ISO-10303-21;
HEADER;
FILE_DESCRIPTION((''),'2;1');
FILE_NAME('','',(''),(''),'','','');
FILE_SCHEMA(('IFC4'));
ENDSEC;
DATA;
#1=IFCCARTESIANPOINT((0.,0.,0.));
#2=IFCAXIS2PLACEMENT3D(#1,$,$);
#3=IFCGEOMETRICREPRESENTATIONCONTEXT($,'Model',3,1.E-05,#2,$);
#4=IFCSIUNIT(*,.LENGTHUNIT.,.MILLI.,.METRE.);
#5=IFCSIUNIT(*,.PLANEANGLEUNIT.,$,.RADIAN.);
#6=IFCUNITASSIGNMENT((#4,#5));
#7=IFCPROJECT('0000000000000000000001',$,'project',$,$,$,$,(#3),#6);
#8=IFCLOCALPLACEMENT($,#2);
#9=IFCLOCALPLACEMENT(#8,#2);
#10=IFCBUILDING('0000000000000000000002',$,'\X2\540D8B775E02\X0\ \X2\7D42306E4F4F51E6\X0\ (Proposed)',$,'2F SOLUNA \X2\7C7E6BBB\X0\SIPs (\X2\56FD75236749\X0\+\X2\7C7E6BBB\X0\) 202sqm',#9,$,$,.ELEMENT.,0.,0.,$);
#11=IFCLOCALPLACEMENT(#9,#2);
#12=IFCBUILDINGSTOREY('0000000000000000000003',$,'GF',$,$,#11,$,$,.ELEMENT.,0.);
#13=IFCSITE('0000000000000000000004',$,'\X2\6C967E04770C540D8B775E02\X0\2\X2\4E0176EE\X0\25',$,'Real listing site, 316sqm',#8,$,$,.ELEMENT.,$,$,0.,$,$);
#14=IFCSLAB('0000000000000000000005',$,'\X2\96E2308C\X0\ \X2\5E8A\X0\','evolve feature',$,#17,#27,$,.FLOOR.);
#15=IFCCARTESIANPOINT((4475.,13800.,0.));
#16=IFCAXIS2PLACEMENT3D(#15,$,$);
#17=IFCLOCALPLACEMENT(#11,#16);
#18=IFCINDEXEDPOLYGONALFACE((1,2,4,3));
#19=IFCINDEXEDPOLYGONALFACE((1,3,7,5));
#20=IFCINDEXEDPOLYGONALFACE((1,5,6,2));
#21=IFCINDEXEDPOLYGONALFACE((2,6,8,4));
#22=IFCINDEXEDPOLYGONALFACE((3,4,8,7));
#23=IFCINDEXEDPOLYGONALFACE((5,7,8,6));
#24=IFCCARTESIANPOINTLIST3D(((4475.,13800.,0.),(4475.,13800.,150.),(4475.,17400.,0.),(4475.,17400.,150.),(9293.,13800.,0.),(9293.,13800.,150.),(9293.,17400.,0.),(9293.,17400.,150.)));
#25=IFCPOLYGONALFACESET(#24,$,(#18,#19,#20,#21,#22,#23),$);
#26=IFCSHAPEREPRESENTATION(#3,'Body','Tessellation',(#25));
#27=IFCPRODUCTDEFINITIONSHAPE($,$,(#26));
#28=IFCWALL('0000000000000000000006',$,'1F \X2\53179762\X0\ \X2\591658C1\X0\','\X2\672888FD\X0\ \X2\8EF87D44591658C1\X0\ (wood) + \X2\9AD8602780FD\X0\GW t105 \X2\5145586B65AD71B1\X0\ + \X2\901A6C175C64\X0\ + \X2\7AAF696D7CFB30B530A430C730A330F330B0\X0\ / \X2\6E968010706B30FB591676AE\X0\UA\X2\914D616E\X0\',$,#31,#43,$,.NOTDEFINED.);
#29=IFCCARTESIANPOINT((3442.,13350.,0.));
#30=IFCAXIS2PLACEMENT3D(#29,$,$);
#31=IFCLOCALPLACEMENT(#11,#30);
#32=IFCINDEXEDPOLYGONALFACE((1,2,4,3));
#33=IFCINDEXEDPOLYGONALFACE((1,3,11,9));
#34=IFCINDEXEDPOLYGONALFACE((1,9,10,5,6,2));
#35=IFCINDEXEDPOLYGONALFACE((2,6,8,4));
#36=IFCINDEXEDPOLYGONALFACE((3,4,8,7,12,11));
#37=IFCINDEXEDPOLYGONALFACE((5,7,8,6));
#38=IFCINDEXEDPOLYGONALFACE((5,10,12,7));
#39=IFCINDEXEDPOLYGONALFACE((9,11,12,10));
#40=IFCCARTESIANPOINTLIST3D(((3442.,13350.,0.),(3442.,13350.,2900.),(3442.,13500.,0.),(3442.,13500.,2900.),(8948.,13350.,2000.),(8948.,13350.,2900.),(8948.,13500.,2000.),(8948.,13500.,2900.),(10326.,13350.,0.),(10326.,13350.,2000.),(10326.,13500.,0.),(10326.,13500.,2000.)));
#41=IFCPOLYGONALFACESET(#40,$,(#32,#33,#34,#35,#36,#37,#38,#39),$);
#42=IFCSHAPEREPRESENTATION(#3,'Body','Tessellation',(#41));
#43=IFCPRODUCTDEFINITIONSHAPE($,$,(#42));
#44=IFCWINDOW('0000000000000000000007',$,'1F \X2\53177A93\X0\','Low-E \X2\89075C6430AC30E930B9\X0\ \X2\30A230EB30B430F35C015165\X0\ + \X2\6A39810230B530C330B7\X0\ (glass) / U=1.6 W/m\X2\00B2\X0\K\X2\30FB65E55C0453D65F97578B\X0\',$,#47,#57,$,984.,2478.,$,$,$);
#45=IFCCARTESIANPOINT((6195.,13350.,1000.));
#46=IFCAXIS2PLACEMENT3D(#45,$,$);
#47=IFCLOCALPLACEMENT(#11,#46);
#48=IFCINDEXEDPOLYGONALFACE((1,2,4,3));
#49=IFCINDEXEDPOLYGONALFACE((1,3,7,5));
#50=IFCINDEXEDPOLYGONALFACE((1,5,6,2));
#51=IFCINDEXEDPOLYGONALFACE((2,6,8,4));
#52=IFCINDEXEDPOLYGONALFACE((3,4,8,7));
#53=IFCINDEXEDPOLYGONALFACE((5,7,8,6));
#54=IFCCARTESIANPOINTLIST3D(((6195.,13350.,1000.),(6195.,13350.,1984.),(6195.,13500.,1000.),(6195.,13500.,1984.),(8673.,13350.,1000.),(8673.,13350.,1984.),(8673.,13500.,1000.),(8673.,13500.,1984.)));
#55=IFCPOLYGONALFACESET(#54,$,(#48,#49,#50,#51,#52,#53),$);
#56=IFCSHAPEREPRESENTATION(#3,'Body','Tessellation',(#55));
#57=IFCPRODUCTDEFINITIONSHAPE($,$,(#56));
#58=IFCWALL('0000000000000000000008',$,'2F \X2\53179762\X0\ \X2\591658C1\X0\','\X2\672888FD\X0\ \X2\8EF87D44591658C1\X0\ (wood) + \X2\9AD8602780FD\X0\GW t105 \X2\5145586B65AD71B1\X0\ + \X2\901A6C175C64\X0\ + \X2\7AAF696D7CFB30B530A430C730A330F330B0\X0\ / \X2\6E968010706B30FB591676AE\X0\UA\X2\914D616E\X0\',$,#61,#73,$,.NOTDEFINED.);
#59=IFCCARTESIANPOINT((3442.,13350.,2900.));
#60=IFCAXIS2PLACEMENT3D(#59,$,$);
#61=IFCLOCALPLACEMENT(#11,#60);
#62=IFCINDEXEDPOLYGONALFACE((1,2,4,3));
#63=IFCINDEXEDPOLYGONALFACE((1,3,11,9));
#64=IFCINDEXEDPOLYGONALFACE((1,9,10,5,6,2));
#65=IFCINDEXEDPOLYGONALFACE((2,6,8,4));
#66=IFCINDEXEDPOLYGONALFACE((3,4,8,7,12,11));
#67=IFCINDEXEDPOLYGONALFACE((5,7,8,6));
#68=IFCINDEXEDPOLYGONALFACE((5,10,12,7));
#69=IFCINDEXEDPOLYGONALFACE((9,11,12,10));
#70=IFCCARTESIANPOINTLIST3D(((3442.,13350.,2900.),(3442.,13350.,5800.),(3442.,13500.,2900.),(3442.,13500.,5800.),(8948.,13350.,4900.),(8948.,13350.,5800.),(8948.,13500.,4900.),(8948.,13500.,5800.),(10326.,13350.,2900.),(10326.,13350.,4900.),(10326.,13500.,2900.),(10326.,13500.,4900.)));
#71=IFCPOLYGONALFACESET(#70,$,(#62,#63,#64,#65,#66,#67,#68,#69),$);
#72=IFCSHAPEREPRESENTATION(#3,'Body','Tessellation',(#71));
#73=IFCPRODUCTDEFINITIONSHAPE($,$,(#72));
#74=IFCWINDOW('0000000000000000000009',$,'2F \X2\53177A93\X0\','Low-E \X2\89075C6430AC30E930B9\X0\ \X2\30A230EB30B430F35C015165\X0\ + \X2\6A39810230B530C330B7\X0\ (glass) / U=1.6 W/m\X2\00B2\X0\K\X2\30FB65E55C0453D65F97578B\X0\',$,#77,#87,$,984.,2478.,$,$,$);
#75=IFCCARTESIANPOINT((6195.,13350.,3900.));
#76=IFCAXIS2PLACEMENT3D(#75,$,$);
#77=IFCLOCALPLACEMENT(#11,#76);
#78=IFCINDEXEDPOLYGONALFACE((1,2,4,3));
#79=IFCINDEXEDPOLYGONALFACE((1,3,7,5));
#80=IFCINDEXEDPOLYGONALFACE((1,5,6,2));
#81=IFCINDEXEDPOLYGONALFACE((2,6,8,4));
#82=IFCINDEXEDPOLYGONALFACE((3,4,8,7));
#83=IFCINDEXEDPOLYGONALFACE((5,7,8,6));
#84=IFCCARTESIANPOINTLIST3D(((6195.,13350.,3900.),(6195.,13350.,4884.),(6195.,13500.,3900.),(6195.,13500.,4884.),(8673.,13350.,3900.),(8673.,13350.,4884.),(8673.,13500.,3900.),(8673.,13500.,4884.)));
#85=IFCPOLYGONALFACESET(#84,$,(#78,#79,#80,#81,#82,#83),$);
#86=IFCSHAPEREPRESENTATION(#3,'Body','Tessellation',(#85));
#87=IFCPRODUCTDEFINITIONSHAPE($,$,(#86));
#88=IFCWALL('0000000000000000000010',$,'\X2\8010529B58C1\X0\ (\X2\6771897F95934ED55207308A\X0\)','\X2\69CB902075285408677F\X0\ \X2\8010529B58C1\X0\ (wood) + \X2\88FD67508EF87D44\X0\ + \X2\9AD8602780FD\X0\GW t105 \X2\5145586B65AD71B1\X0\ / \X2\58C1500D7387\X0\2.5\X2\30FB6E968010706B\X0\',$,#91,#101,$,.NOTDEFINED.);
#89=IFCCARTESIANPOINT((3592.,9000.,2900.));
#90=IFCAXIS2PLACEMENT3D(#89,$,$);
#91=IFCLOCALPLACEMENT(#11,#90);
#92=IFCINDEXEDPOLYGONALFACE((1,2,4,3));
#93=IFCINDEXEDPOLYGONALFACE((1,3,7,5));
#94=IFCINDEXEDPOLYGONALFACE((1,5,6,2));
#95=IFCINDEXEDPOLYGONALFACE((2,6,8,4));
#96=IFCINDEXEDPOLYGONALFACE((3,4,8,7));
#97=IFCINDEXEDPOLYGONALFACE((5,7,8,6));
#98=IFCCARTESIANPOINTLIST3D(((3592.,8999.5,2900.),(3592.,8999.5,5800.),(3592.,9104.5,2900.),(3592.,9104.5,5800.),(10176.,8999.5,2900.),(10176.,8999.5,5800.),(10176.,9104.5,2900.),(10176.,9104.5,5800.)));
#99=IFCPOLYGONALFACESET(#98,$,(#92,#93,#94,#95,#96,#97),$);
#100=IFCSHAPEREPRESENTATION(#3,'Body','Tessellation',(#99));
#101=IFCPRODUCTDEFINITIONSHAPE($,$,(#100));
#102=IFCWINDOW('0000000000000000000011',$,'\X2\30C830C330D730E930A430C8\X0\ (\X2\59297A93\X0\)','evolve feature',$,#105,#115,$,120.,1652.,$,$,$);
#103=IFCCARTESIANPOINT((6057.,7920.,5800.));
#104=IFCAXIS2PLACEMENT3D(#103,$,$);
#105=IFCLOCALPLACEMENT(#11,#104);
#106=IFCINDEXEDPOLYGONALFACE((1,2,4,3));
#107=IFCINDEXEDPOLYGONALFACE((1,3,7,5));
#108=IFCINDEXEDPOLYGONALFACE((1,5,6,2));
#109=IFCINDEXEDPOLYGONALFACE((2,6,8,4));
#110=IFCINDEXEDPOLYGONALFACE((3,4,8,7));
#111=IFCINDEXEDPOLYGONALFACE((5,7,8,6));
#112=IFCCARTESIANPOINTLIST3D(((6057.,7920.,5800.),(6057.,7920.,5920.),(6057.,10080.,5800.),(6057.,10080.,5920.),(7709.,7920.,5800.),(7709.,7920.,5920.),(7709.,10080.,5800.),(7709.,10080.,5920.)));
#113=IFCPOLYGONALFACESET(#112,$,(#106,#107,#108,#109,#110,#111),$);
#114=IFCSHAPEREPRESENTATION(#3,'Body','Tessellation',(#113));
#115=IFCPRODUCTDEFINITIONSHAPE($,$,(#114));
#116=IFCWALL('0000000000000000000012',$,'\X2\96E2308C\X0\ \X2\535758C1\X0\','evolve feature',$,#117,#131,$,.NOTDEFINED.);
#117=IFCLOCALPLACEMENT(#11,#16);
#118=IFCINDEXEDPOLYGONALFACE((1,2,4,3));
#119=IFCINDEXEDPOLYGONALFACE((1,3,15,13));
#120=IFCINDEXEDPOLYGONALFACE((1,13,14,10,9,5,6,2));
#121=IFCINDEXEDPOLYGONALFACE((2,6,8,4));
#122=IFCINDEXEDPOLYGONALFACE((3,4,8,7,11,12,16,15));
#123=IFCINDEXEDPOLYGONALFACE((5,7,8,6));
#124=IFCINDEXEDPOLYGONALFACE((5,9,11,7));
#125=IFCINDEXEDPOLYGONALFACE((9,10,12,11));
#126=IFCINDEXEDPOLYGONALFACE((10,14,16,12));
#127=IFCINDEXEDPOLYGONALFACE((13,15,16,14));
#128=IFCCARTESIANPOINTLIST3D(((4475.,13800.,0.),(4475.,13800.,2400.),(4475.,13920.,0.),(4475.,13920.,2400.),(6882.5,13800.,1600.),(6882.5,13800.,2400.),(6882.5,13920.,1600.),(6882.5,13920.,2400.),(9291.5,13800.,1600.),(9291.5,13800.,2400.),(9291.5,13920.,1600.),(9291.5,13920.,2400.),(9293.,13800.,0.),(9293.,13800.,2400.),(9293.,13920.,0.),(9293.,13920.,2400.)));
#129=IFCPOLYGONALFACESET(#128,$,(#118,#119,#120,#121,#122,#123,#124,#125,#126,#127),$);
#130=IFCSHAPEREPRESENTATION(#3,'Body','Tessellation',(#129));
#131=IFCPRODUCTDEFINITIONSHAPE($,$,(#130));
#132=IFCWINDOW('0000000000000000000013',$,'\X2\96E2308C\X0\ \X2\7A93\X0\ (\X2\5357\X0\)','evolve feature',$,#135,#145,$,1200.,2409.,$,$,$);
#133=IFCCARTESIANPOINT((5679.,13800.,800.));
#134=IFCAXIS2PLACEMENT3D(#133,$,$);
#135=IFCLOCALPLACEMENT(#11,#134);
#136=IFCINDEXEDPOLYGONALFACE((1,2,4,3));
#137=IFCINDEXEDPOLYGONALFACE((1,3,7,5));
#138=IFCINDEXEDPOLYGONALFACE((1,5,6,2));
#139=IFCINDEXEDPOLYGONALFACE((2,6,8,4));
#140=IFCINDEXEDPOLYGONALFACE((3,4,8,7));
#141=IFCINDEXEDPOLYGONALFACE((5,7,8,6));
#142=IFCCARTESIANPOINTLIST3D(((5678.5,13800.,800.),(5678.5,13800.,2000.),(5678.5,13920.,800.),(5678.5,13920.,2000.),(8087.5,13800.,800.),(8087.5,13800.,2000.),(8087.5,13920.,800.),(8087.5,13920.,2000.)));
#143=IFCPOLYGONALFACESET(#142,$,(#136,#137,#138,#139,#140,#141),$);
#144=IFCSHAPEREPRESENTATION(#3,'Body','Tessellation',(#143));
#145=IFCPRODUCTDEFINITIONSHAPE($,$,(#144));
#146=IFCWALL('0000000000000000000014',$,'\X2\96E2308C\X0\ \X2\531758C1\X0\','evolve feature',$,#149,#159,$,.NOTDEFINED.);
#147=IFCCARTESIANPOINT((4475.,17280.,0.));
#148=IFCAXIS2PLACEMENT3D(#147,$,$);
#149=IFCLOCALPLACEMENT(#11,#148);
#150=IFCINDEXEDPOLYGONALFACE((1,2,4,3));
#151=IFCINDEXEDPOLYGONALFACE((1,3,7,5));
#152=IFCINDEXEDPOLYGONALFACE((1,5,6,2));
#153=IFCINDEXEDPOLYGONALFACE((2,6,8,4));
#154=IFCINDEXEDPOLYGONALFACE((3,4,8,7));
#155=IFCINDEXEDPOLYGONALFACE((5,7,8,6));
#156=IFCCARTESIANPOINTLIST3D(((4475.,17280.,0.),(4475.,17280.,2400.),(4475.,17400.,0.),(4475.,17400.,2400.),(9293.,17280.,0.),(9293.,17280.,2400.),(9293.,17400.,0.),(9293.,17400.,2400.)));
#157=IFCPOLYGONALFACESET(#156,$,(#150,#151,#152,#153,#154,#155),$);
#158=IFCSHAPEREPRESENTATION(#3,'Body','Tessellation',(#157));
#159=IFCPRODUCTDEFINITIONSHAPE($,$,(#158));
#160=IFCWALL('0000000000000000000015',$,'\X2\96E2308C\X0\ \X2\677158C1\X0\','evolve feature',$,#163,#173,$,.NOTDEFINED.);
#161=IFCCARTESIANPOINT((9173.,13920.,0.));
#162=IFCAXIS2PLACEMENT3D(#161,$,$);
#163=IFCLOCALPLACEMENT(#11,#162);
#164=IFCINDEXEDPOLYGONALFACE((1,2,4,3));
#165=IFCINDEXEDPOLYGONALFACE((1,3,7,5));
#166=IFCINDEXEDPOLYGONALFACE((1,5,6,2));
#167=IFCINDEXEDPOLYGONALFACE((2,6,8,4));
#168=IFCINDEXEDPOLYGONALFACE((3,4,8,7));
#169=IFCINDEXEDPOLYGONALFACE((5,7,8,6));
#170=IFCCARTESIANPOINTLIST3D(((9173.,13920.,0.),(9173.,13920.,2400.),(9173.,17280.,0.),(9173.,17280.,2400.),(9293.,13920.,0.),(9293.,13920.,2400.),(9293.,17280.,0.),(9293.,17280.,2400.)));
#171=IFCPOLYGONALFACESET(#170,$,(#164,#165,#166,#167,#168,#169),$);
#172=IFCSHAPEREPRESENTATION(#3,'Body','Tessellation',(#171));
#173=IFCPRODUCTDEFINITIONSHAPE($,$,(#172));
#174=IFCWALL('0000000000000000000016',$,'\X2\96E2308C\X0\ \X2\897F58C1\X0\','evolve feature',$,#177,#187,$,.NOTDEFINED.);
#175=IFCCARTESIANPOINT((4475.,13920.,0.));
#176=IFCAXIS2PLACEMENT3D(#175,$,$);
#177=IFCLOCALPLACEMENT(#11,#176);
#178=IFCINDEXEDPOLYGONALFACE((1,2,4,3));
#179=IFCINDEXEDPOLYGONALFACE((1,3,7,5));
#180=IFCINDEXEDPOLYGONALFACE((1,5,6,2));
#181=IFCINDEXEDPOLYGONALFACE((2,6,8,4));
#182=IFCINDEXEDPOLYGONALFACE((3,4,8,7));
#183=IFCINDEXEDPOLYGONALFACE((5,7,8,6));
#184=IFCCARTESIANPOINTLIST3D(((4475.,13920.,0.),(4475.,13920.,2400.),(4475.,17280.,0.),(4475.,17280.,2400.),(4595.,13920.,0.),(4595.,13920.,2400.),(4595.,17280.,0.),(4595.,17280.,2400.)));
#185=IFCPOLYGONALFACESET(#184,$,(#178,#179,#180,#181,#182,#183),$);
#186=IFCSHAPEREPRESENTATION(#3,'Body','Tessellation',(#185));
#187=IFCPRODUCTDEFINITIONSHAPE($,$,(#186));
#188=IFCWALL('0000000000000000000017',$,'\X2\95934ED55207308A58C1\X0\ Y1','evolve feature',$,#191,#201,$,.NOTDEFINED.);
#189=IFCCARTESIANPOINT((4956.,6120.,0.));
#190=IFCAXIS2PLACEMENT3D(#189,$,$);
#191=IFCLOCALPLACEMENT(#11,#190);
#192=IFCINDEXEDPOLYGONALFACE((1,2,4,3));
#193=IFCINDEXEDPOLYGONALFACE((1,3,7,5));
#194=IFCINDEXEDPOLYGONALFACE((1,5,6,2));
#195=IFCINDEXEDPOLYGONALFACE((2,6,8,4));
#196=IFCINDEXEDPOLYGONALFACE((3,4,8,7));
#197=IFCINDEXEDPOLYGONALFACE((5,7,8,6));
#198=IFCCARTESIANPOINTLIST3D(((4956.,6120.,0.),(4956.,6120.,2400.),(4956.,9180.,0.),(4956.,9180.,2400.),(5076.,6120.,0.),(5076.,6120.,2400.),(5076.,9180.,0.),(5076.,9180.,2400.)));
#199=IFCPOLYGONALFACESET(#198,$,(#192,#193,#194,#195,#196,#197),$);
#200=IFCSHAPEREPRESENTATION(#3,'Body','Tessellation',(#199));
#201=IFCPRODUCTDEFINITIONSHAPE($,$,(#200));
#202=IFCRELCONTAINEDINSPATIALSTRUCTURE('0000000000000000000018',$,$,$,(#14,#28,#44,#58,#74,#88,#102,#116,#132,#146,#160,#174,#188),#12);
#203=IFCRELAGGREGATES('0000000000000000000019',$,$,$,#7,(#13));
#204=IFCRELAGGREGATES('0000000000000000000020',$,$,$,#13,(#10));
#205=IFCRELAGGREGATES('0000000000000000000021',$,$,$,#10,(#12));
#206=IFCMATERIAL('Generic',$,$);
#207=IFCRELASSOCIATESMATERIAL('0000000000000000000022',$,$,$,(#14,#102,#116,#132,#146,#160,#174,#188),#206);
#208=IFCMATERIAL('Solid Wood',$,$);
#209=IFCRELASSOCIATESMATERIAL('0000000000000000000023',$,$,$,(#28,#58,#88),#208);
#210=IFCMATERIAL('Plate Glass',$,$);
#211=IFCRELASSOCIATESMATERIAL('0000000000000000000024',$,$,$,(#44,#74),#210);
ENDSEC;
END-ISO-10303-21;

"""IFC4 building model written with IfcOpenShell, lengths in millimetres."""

from ifc_helpers import new_model, si_unit, frame, frame_2d, origin, place, context, project, spatial, rectangle, extrude, material, element, fill, save


model = new_model("IFC4")

# Units and contexts
model_context = context("Model", 3, precision=1e-05, world=origin())
ifc_project = project(units=[si_unit("LENGTHUNIT", "METRE", prefix="MILLI"), si_unit("PLANEANGLEUNIT", "RADIAN")], contexts=[model_context])

# Site, building, storey
site_placement = place(None, origin())
site = spatial("IfcSite", under=ifc_project, at=site_placement, Name="沖縄県名護市2丁目25", ObjectType="Real listing site, 316sqm", CompositionType="ELEMENT", RefElevation=0.0)
building_placement = place(site_placement, origin())
building = spatial("IfcBuilding", under=site, at=building_placement, Name="名護市 終の住処 (Proposed)", ObjectType="2F SOLUNA 籾殻SIPs (国産杉+籾殻) 202sqm", CompositionType="ELEMENT", ElevationOfRefHeight=0.0, ElevationOfTerrain=0.0)
storey_placement = place(building_placement, origin())
storey = spatial("IfcBuildingStorey", under=building, at=storey_placement, Name="GF", CompositionType="ELEMENT", Elevation=0.0)

# Slab
ifc_material_1 = material(Name="Generic")
slab_placement = place(storey_placement, frame((4475.0, 13800.0, 0.0)))
element("IfcSlab", 1, at=slab_placement, inside=storey, material=ifc_material_1, Name="離れ 床", Description="evolve feature", PredefinedType="FLOOR", context=model_context, shape_type="SweptSolid", body=[
    extrude(rectangle(XDim=4818.0, YDim=3600.0, at=frame_2d((2409.0, 1800.0))), frame((4475.0, 13800.0, 0.0)), (0.0, 0.0, 1.0), 150.0),
])

# Wall, opening, window
ifc_material_2 = material(Name="Solid Wood")
wall_1_placement = place(storey_placement, frame((3442.0, 13350.0, 0.0)))
wall_1 = element("IfcWall", 2, at=wall_1_placement, inside=storey, material=ifc_material_2, Name="1F 北面 外壁", Description="木製 軸組外壁 (wood) + 高性能GW t105 充填断熱 + 通気層 + 窯業系サイディング / 準耐火・外皮UA配慮", PredefinedType="NOTDEFINED", context=model_context, shape_type="SweptSolid", body=[
    extrude(rectangle(XDim=6884.0, YDim=150.0, at=frame_2d((3442.0, 75.0))), frame((3442.0, 13350.0, 0.0)), (0.0, 0.0, 1.0), 2900.0),
])
opening_1_placement = place(storey_placement, frame((6195.0, 13350.0, 1000.0)))
opening_1 = element("IfcOpeningElement", 3, at=opening_1_placement, cuts=wall_1, PredefinedType="NOTDEFINED", context=model_context, shape_type="SweptSolid", body=[
    extrude(rectangle(XDim=2478.0, YDim=150.0, at=frame_2d((1239.0, 75.0))), frame((6195.0, 13350.0, 1000.0)), (0.0, 0.0, 1.0), 984.0),
])
ifc_material_3 = material(Name="Plate Glass")
window_1_placement = place(storey_placement, frame((6195.0, 13350.0, 1000.0)))
window_1 = element("IfcWindow", 4, at=window_1_placement, inside=storey, material=ifc_material_3, Name="1F 北窓", Description="Low-E 複層ガラス アルゴン封入 + 樹脂サッシ (glass) / U=1.6 W/m²K・日射取得型", OverallHeight=984.0, OverallWidth=2478.0, context=model_context, shape_type="SweptSolid", body=[
    extrude(rectangle(XDim=2478.0, YDim=150.0, at=frame_2d((1239.0, 75.0))), frame((6195.0, 13350.0, 1000.0)), (0.0, 0.0, 1.0), 984.0),
])
fill(opening_1, window_1)

# Wall, opening, window
wall_2_placement = place(storey_placement, frame((3442.0, 13350.0, 2900.0)))
wall_2 = element("IfcWall", 5, at=wall_2_placement, inside=storey, material=ifc_material_2, Name="2F 北面 外壁", Description="木製 軸組外壁 (wood) + 高性能GW t105 充填断熱 + 通気層 + 窯業系サイディング / 準耐火・外皮UA配慮", PredefinedType="NOTDEFINED", context=model_context, shape_type="SweptSolid", body=[
    extrude(rectangle(XDim=6884.0, YDim=150.0, at=frame_2d((3442.0, 75.0))), frame((3442.0, 13350.0, 2900.0)), (0.0, 0.0, 1.0), 2900.0),
])
opening_2_placement = place(storey_placement, frame((6195.0, 13350.0, 3900.0)))
opening_2 = element("IfcOpeningElement", 6, at=opening_2_placement, cuts=wall_2, PredefinedType="NOTDEFINED", context=model_context, shape_type="SweptSolid", body=[
    extrude(rectangle(XDim=2478.0, YDim=150.0, at=frame_2d((1239.0, 75.0))), frame((6195.0, 13350.0, 3900.0)), (0.0, 0.0, 1.0), 984.0),
])
window_2_placement = place(storey_placement, frame((6195.0, 13350.0, 3900.0)))
window_2 = element("IfcWindow", 7, at=window_2_placement, inside=storey, material=ifc_material_3, Name="2F 北窓", Description="Low-E 複層ガラス アルゴン封入 + 樹脂サッシ (glass) / U=1.6 W/m²K・日射取得型", OverallHeight=984.0, OverallWidth=2478.0, context=model_context, shape_type="SweptSolid", body=[
    extrude(rectangle(XDim=2478.0, YDim=150.0, at=frame_2d((1239.0, 75.0))), frame((6195.0, 13350.0, 3900.0)), (0.0, 0.0, 1.0), 984.0),
])
fill(opening_2, window_2)

# Wall
wall_3_placement = place(storey_placement, frame((3592.0, 9000.0, 2900.0)))
element("IfcWall", 8, at=wall_3_placement, inside=storey, material=ifc_material_2, Name="耐力壁 (東西間仕切り)", Description="構造用合板 耐力壁 (wood) + 製材軸組 + 高性能GW t105 充填断熱 / 壁倍率2.5・準耐火", PredefinedType="NOTDEFINED", context=model_context, shape_type="SweptSolid", body=[
    extrude(rectangle(XDim=6584.0, YDim=105.0, at=frame_2d((3292.0, 52.0))), frame((3592.0, 9000.0, 2900.0)), (0.0, 0.0, 1.0), 2900.0),
])

# Window
window_3_placement = place(storey_placement, frame((6057.0, 7920.0, 5800.0)))
element("IfcWindow", 9, at=window_3_placement, inside=storey, material=ifc_material_1, Name="トップライト (天窓)", Description="evolve feature", OverallHeight=120.0, OverallWidth=1652.0, context=model_context, shape_type="SweptSolid", body=[
    extrude(rectangle(XDim=1652.0, YDim=2160.0, at=frame_2d((826.0, 1080.0))), frame((6057.0, 7920.0, 5800.0)), (0.0, 0.0, 1.0), 120.0),
])

# Wall, opening, window
wall_4_placement = place(storey_placement, frame((4475.0, 13800.0, 0.0)))
wall_4 = element("IfcWall", 10, at=wall_4_placement, inside=storey, material=ifc_material_1, Name="離れ 南壁", Description="evolve feature", PredefinedType="NOTDEFINED", context=model_context, shape_type="SweptSolid", body=[
    extrude(rectangle(XDim=4818.0, YDim=120.0, at=frame_2d((2409.0, 60.0))), frame((4475.0, 13800.0, 0.0)), (0.0, 0.0, 1.0), 2400.0),
])
opening_3_placement = place(storey_placement, frame((5679.0, 13800.0, 800.0)))
opening_3 = element("IfcOpeningElement", 11, at=opening_3_placement, cuts=wall_4, PredefinedType="NOTDEFINED", context=model_context, shape_type="SweptSolid", body=[
    extrude(rectangle(XDim=2409.0, YDim=120.0, at=frame_2d((1204.0, 60.0))), frame((5679.0, 13800.0, 800.0)), (0.0, 0.0, 1.0), 1200.0),
])
window_4_placement = place(storey_placement, frame((5679.0, 13800.0, 800.0)))
window_4 = element("IfcWindow", 12, at=window_4_placement, inside=storey, material=ifc_material_1, Name="離れ 窓 (南)", Description="evolve feature", OverallHeight=1200.0, OverallWidth=2409.0, context=model_context, shape_type="SweptSolid", body=[
    extrude(rectangle(XDim=2409.0, YDim=120.0, at=frame_2d((1204.0, 60.0))), frame((5679.0, 13800.0, 800.0)), (0.0, 0.0, 1.0), 1200.0),
])
fill(opening_3, window_4)

# Walls
wall_5_placement = place(storey_placement, frame((4475.0, 17280.0, 0.0)))
element("IfcWall", 13, at=wall_5_placement, inside=storey, material=ifc_material_1, Name="離れ 北壁", Description="evolve feature", PredefinedType="NOTDEFINED", context=model_context, shape_type="SweptSolid", body=[
    extrude(rectangle(XDim=4818.0, YDim=120.0, at=frame_2d((2409.0, 60.0))), frame((4475.0, 17280.0, 0.0)), (0.0, 0.0, 1.0), 2400.0),
])
wall_6_placement = place(storey_placement, frame((9173.0, 13920.0, 0.0)))
element("IfcWall", 14, at=wall_6_placement, inside=storey, material=ifc_material_1, Name="離れ 東壁", Description="evolve feature", PredefinedType="NOTDEFINED", context=model_context, shape_type="SweptSolid", body=[
    extrude(rectangle(XDim=120.0, YDim=3360.0, at=frame_2d((60.0, 1680.0))), frame((9173.0, 13920.0, 0.0)), (0.0, 0.0, 1.0), 2400.0),
])
wall_7_placement = place(storey_placement, frame((4475.0, 13920.0, 0.0)))
element("IfcWall", 15, at=wall_7_placement, inside=storey, material=ifc_material_1, Name="離れ 西壁", Description="evolve feature", PredefinedType="NOTDEFINED", context=model_context, shape_type="SweptSolid", body=[
    extrude(rectangle(XDim=120.0, YDim=3360.0, at=frame_2d((60.0, 1680.0))), frame((4475.0, 13920.0, 0.0)), (0.0, 0.0, 1.0), 2400.0),
])
wall_8_placement = place(storey_placement, frame((4956.0, 6120.0, 0.0)))
element("IfcWall", 16, at=wall_8_placement, inside=storey, material=ifc_material_1, Name="間仕切り壁 Y1", Description="evolve feature", PredefinedType="NOTDEFINED", context=model_context, shape_type="SweptSolid", body=[
    extrude(rectangle(XDim=120.0, YDim=3060.0, at=frame_2d((60.0, 1530.0))), frame((4956.0, 6120.0, 0.0)), (0.0, 0.0, 1.0), 2400.0),
])

save(model, "model.ifc")
